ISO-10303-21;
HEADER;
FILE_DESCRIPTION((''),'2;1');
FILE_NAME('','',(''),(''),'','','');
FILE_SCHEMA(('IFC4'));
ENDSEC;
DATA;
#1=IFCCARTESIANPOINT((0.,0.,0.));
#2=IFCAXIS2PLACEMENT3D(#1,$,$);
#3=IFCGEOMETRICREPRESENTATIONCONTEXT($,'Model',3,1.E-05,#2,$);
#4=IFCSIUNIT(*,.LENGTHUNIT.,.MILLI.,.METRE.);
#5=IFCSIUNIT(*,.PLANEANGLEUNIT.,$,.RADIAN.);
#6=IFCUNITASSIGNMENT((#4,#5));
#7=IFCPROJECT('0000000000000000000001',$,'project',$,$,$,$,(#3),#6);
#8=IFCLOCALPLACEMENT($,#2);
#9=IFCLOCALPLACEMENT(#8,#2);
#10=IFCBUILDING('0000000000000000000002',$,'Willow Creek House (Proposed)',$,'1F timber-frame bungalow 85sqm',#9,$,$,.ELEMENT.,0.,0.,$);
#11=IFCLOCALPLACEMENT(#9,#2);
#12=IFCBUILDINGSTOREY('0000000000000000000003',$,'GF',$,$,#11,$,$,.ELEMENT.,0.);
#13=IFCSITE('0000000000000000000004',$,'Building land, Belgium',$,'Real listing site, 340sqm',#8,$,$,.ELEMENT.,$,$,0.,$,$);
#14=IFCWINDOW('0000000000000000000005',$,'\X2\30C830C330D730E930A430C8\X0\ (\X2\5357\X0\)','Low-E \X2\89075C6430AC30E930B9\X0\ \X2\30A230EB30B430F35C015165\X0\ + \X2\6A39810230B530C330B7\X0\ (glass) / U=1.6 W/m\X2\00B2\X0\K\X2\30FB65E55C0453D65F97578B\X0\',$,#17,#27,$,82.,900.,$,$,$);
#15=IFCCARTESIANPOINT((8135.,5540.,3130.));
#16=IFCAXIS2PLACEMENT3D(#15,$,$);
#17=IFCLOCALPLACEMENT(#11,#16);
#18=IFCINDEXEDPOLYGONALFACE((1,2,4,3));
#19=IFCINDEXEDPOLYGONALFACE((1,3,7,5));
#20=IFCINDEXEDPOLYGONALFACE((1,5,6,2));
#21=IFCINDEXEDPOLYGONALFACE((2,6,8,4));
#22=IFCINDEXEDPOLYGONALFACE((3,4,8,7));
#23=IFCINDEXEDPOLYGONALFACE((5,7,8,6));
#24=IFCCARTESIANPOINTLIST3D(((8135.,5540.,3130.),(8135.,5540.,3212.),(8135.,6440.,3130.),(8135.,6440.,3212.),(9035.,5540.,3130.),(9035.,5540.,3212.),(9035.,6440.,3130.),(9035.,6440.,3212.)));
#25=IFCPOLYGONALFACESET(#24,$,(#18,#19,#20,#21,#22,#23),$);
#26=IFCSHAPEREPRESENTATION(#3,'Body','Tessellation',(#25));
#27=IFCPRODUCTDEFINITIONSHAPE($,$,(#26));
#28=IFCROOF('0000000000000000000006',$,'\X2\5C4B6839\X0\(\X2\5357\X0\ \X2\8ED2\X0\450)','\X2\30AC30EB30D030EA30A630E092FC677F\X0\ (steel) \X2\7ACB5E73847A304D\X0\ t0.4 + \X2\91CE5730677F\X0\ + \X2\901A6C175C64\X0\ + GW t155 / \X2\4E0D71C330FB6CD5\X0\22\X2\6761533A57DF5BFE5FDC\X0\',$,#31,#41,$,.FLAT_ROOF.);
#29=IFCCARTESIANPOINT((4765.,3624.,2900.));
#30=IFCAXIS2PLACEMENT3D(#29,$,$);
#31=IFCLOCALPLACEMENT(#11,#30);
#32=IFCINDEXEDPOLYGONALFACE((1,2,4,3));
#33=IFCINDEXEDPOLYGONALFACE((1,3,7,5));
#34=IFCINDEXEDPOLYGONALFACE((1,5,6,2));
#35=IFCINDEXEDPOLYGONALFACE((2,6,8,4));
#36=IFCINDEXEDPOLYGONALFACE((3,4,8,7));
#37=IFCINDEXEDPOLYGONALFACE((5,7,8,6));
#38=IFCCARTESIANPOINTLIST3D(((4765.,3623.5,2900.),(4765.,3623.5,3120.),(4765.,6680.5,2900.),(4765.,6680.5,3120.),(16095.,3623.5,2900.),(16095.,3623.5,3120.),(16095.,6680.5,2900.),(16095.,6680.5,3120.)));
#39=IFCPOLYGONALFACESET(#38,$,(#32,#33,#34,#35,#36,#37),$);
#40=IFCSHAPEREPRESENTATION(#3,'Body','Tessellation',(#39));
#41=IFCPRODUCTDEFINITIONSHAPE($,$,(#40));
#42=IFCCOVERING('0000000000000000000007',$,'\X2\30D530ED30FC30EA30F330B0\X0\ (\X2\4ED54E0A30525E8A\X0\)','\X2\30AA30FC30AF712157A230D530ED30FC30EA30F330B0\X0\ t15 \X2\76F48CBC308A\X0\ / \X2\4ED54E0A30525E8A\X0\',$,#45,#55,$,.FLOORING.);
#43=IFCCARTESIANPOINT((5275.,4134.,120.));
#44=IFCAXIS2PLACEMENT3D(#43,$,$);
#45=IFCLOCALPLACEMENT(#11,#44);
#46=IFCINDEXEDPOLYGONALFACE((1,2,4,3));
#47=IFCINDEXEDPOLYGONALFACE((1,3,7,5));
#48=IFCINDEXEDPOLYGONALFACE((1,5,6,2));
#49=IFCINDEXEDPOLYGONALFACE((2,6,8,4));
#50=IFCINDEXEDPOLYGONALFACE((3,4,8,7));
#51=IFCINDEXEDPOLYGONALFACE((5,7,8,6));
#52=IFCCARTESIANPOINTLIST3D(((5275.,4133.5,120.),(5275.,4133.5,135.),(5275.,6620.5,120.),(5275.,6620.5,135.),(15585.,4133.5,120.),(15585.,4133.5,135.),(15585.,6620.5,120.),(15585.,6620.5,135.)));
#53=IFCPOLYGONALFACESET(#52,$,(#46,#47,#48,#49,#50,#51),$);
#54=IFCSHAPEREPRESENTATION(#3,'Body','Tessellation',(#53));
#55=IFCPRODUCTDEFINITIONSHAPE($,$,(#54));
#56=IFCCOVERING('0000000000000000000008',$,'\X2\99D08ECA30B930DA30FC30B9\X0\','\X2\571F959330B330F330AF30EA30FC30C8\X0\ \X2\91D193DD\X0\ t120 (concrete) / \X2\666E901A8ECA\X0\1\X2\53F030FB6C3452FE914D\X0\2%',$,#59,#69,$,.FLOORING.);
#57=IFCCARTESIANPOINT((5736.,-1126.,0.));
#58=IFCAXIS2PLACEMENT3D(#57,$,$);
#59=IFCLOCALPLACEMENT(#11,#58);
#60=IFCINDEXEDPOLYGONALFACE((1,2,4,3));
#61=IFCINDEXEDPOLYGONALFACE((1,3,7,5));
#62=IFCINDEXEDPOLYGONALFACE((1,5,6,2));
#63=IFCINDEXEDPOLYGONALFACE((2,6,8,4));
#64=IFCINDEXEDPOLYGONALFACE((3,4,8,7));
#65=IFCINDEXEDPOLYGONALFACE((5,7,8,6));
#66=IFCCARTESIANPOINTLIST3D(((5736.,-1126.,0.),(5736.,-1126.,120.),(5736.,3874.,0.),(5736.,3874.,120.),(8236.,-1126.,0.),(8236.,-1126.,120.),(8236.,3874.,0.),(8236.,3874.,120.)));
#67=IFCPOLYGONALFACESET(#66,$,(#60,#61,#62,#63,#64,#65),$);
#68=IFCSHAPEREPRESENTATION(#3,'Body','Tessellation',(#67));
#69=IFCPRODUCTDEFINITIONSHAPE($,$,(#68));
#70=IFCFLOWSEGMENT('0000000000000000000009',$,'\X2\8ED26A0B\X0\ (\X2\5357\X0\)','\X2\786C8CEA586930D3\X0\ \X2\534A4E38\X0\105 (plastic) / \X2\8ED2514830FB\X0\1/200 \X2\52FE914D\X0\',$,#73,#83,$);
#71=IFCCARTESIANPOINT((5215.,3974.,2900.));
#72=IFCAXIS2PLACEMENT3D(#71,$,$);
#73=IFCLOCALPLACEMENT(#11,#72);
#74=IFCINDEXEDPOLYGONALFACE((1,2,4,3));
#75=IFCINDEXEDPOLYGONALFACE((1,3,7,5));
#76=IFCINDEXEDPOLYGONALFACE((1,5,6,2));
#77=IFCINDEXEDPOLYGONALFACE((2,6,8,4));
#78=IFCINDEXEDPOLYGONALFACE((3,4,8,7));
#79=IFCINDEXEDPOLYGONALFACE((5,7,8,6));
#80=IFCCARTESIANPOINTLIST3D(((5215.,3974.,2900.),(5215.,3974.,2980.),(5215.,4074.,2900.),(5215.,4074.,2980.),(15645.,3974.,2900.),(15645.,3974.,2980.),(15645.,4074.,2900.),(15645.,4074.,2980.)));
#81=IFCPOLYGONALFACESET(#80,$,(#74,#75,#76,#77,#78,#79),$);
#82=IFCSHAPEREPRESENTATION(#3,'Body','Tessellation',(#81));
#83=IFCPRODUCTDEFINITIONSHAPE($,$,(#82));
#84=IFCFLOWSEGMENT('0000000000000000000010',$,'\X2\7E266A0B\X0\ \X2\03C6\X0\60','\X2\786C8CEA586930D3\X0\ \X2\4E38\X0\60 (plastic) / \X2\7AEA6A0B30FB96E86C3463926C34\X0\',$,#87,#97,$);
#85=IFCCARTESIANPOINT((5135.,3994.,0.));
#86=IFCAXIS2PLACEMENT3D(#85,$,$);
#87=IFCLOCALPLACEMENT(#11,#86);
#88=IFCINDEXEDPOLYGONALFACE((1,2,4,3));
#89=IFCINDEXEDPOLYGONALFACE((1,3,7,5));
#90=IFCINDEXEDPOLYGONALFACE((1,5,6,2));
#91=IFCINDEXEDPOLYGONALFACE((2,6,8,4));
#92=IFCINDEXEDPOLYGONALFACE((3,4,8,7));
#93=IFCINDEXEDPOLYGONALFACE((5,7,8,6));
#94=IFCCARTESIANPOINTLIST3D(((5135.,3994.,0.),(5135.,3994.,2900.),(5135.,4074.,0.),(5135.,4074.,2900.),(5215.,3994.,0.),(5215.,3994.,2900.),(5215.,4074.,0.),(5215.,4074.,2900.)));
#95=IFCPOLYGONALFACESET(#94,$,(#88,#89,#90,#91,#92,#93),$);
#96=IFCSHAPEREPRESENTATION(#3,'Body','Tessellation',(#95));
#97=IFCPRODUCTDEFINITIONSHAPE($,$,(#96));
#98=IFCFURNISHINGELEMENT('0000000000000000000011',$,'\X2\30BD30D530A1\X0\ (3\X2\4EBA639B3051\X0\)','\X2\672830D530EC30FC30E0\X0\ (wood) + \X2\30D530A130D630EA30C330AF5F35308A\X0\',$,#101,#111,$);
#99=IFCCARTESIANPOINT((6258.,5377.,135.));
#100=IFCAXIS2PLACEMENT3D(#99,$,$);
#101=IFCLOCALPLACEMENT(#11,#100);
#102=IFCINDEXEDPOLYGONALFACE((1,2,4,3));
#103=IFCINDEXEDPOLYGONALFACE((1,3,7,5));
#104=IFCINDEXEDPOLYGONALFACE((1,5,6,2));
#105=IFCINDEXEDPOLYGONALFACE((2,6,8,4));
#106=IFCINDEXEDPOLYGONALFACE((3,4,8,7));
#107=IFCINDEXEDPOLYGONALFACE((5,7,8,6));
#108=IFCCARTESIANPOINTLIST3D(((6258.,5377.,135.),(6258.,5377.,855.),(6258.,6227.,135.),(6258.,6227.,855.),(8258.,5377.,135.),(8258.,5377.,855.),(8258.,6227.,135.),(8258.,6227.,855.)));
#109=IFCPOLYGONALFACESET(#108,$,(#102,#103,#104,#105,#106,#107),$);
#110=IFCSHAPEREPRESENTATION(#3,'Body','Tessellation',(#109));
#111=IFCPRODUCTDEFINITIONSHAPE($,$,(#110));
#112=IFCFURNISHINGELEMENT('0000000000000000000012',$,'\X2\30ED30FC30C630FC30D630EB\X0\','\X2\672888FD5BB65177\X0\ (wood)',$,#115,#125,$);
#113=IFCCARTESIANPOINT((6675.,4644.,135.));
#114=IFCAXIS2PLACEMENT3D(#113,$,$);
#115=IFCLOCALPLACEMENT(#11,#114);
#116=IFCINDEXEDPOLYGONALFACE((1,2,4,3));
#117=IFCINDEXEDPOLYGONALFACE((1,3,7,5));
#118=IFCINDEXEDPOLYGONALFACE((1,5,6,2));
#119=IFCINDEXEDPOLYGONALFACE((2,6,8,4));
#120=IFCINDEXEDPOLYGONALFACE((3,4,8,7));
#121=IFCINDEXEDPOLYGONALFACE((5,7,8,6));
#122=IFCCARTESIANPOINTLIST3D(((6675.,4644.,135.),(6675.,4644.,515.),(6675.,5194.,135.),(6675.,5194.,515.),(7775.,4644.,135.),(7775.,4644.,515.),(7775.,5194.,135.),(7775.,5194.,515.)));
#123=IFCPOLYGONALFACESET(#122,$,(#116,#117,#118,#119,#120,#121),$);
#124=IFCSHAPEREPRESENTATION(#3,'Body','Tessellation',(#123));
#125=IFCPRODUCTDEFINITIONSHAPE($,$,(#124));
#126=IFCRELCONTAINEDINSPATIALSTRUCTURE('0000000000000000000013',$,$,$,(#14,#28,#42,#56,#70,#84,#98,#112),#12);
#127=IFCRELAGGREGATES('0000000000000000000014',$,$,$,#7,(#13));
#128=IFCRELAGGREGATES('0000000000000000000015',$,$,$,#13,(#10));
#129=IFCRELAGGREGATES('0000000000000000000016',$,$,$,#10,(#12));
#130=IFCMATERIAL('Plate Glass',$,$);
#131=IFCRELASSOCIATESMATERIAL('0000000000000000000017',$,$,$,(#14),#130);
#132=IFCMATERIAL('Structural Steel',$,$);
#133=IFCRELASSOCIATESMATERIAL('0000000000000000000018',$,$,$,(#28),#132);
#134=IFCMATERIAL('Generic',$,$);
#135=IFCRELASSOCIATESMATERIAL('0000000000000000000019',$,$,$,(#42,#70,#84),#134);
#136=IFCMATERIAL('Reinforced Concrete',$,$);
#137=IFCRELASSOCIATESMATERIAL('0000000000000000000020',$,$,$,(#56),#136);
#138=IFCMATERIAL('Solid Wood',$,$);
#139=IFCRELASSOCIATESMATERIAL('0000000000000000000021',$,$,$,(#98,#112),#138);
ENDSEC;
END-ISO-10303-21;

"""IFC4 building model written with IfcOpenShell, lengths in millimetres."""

from ifc_helpers import new_model, si_unit, frame, frame_2d, origin, place, context, project, spatial, rectangle, extrude, material, element, save


model = new_model("IFC4")

# Units and contexts
model_context = context("Model", 3, precision=1e-05, world=origin())
ifc_project = project(units=[si_unit("LENGTHUNIT", "METRE", prefix="MILLI"), si_unit("PLANEANGLEUNIT", "RADIAN")], contexts=[model_context])

# Site, building, storey
site_placement = place(None, origin())
site = spatial("IfcSite", under=ifc_project, at=site_placement, Name="Building land, Belgium", ObjectType="Real listing site, 340sqm", CompositionType="ELEMENT", RefElevation=0.0)
building_placement = place(site_placement, origin())
building = spatial("IfcBuilding", under=site, at=building_placement, Name="Willow Creek House (Proposed)", ObjectType="1F timber-frame bungalow 85sqm", CompositionType="ELEMENT", ElevationOfRefHeight=0.0, ElevationOfTerrain=0.0)
storey_placement = place(building_placement, origin())
storey = spatial("IfcBuildingStorey", under=building, at=storey_placement, Name="GF", CompositionType="ELEMENT", Elevation=0.0)

# Shared definitions
ifc_material_1 = material(Name="Solid Wood")

# Shared definitions
ifc_material_2 = material(Name="Reinforced Concrete")

# Shared definitions
ifc_material_3 = material(Name="Plate Glass")

# Window
window_1_placement = place(storey_placement, frame((8135.0, 5540.0, 3130.0)))
element("IfcWindow", 1, at=window_1_placement, inside=storey, material=ifc_material_3, Name="トップライト (南)", Description="Low-E 複層ガラス アルゴン封入 + 樹脂サッシ (glass) / U=1.6 W/m²K・日射取得型", OverallHeight=82.0, OverallWidth=900.0, context=model_context, shape_type="SweptSolid", body=[
    extrude(rectangle(XDim=900.0, YDim=900.0, at=frame_2d((450.0, 450.0))), frame((8135.0, 5540.0, 3130.0)), (0.0, 0.0, 1.0), 82.0),
])

# Roof
ifc_material_4 = material(Name="Structural Steel")
roof_1_placement = place(storey_placement, frame((4765.0, 3624.0, 2900.0)))
element("IfcRoof", 2, at=roof_1_placement, inside=storey, material=ifc_material_4, Name="屋根(南 軒450)", Description="ガルバリウム鋼板 (steel) 立平葺き t0.4 + 野地板 + 通気層 + GW t155 / 不燃・法22条区域対応", PredefinedType="FLAT_ROOF", context=model_context, shape_type="SweptSolid", body=[
    extrude(rectangle(XDim=11330.0, YDim=3057.0, at=frame_2d((5665.0, 1528.0))), frame((4765.0, 3624.0, 2900.0)), (0.0, 0.0, 1.0), 220.0),
])

# Coverings
ifc_material_5 = material(Name="Generic")
covering_1_placement = place(storey_placement, frame((5275.0, 4134.0, 120.0)))
element("IfcCovering", 3, at=covering_1_placement, inside=storey, material=ifc_material_5, Name="フローリング (仕上げ床)", Description="オーク無垢フローリング t15 直貼り / 仕上げ床", PredefinedType="FLOORING", context=model_context, shape_type="SweptSolid", body=[
    extrude(rectangle(XDim=10310.0, YDim=2487.0, at=frame_2d((5155.0, 1243.0))), frame((5275.0, 4134.0, 120.0)), (0.0, 0.0, 1.0), 15.0),
])
covering_2_placement = place(storey_placement, frame((5736.0, -1126.0, 0.0)))
element("IfcCovering", 4, at=covering_2_placement, inside=storey, material=ifc_material_2, Name="駐車スペース", Description="土間コンクリート 金鏝 t120 (concrete) / 普通車1台・水勾配2%", PredefinedType="FLOORING", context=model_context, shape_type="SweptSolid", body=[
    extrude(rectangle(XDim=2500.0, YDim=5000.0, at=frame_2d((1250.0, 2500.0))), frame((5736.0, -1126.0, 0.0)), (0.0, 0.0, 1.0), 120.0),
])

# Flow segments
flow_segment_1_placement = place(storey_placement, frame((5215.0, 3974.0, 2900.0)))
element("IfcFlowSegment", 5, at=flow_segment_1_placement, inside=storey, material=ifc_material_5, Name="軒樋 (南)", Description="硬質塩ビ 半丸105 (plastic) / 軒先・1/200 勾配", context=model_context, shape_type="SweptSolid", body=[
    extrude(rectangle(XDim=10430.0, YDim=100.0, at=frame_2d((5215.0, 50.0))), frame((5215.0, 3974.0, 2900.0)), (0.0, 0.0, 1.0), 80.0),
])
flow_segment_2_placement = place(storey_placement, frame((5135.0, 3994.0, 0.0)))
element("IfcFlowSegment", 6, at=flow_segment_2_placement, inside=storey, material=ifc_material_5, Name="縦樋 φ60", Description="硬質塩ビ 丸60 (plastic) / 竪樋・雨水排水", context=model_context, shape_type="SweptSolid", body=[
    extrude(rectangle(XDim=80.0, YDim=80.0, at=frame_2d((40.0, 40.0))), frame((5135.0, 3994.0, 0.0)), (0.0, 0.0, 1.0), 2900.0),
])

# Furnishing elements
furnishing_1_placement = place(storey_placement, frame((6258.0, 5377.0, 135.0)))
element("IfcFurnishingElement", 7, at=furnishing_1_placement, inside=storey, material=ifc_material_1, Name="ソファ (3人掛け)", Description="木フレーム (wood) + ファブリック張り", context=model_context, shape_type="SweptSolid", body=[
    extrude(rectangle(XDim=2000.0, YDim=850.0, at=frame_2d((1000.0, 425.0))), frame((6258.0, 5377.0, 135.0)), (0.0, 0.0, 1.0), 720.0),
])
furnishing_2_placement = place(storey_placement, frame((6675.0, 4644.0, 135.0)))
element("IfcFurnishingElement", 8, at=furnishing_2_placement, inside=storey, material=ifc_material_1, Name="ローテーブル", Description="木製家具 (wood)", context=model_context, shape_type="SweptSolid", body=[
    extrude(rectangle(XDim=1100.0, YDim=550.0, at=frame_2d((550.0, 275.0))), frame((6675.0, 4644.0, 135.0)), (0.0, 0.0, 1.0), 380.0),
])

save(model, "model.ifc")
